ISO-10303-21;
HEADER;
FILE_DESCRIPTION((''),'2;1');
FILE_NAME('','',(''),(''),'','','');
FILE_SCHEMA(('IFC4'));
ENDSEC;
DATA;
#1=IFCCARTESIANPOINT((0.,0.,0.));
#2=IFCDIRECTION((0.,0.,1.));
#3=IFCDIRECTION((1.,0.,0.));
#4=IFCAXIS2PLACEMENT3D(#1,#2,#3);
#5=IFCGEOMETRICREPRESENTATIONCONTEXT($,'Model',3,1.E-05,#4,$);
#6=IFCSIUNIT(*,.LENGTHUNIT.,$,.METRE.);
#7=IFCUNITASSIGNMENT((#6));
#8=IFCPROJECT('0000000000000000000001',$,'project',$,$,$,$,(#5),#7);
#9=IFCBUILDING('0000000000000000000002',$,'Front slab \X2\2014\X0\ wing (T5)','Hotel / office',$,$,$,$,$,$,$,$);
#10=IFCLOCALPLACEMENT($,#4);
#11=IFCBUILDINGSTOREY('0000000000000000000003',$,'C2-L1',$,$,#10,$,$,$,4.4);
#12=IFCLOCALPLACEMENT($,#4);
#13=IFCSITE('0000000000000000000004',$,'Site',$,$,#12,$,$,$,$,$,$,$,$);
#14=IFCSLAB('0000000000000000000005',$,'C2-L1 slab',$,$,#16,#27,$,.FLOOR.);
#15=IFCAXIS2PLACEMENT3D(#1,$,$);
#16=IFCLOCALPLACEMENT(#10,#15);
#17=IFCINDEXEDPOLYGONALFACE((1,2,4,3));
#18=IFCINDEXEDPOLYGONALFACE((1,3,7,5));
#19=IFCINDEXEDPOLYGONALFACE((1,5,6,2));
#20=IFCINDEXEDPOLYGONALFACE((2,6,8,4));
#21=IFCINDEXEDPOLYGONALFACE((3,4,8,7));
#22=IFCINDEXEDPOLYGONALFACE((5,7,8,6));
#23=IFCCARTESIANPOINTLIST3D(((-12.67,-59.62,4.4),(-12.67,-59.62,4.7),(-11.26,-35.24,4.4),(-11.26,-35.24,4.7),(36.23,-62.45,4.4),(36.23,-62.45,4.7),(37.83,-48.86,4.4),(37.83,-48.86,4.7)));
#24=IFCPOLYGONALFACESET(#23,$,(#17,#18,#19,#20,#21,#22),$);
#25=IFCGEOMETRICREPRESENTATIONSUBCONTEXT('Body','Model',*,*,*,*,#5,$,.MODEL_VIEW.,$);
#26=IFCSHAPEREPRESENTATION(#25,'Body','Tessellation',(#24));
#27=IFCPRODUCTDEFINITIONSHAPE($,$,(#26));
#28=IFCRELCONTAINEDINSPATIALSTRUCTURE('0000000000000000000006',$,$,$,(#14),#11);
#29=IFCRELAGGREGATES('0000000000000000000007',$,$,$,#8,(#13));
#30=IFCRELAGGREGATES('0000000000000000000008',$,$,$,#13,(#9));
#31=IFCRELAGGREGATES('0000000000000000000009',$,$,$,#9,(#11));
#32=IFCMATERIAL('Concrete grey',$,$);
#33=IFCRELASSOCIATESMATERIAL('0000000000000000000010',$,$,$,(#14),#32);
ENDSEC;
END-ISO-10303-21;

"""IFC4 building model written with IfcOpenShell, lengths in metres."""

from ifc_helpers import new_model, si_unit, frame, origin_with_axes, place, context, subcontext, project, spatial, polyline, outline, extrude, material, element, save


model = new_model("IFC4")

# Units and contexts
model_context = context("Model", 3, precision=1e-05, world=origin_with_axes())
body_context = subcontext(model_context, "Body", "Model", "MODEL_VIEW")
ifc_project = project(units=[si_unit("LENGTHUNIT", "METRE")], contexts=[model_context])

# Site, building, storey
site_placement = place(None, origin_with_axes())
site = spatial("IfcSite", under=ifc_project, at=site_placement, Name="Site")
building = spatial("IfcBuilding", under=site, Name="Front slab — wing (T5)", Description="Hotel / office")
storey_placement = place(None, origin_with_axes())
storey = spatial("IfcBuildingStorey", under=building, at=storey_placement, Name="C2-L1", Elevation=4.4)

# Slab
ifc_material_1 = material(Name="Concrete grey")
slab_placement = place(storey_placement, origin_with_axes())
element("IfcSlab", 1, at=slab_placement, inside=storey, material=ifc_material_1, Name="C2-L1 slab", PredefinedType="FLOOR", context=body_context, shape_type="SweptSolid", body=[
    extrude(outline(polyline([(-11.26, -35.24), (-12.67, -59.62), (36.23, -62.45), (37.83, -48.86), (-11.26, -35.24)])), frame((0.0, 0.0, 4.4), z_axis=(0.0, 0.0, 1.0), x_axis=(1.0, 0.0, 0.0)), (0.0, 0.0, 1.0), 0.3),
])

save(model, "model.ifc")
